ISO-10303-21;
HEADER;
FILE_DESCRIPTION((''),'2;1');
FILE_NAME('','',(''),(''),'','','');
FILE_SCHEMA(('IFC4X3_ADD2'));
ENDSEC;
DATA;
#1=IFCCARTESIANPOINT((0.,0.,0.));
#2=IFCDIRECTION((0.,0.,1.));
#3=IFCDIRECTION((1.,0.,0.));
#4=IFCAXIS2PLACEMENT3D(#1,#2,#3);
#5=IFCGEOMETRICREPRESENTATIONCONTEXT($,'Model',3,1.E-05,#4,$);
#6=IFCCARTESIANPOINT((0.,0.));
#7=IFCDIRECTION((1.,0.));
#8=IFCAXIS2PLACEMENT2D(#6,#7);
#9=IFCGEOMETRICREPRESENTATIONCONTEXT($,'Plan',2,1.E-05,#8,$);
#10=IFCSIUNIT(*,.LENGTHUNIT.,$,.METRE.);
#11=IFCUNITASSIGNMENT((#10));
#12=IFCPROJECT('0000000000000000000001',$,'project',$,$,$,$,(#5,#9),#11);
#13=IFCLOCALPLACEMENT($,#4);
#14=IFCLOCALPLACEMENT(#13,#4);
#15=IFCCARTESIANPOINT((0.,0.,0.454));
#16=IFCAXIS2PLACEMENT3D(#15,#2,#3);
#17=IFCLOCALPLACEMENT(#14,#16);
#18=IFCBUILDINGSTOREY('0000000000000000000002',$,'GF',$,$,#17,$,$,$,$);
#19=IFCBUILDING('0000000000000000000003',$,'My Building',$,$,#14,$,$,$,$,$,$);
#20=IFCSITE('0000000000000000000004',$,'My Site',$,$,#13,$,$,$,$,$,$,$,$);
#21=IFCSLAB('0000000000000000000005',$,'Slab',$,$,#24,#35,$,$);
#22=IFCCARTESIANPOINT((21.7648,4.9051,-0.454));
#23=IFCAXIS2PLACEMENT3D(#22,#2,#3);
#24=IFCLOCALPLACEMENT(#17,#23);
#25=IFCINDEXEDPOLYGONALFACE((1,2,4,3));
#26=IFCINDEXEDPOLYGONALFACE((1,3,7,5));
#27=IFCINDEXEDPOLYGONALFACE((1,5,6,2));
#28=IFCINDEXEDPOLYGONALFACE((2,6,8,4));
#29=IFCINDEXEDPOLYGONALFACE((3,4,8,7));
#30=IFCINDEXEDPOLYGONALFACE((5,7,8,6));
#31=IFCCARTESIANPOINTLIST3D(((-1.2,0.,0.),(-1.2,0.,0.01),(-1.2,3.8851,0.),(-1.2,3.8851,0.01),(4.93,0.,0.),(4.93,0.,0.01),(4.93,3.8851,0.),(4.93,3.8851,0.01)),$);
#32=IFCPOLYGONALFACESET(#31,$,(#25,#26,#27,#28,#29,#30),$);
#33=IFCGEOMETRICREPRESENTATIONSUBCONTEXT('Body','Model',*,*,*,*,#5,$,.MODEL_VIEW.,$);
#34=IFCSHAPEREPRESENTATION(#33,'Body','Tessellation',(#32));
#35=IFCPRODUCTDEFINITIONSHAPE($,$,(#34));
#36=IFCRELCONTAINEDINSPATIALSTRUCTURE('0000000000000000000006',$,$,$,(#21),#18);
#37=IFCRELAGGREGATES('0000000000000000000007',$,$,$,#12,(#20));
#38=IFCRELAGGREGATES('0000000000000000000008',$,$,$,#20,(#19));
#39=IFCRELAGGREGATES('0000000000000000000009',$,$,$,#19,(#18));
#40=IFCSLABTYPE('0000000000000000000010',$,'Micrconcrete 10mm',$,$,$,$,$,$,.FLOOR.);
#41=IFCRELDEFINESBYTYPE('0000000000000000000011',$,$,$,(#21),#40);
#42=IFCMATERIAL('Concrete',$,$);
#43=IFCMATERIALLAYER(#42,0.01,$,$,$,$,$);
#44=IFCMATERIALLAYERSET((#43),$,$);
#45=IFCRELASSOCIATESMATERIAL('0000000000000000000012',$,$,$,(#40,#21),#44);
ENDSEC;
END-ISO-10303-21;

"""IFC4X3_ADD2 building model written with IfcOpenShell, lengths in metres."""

from ifc_helpers import new_model, si_unit, frame, origin_with_axes, origin_2d_with_axis, place, context, subcontext, project, spatial, line, indexed_curve, outline, extrude, material, layer, layer_set, layer_usage, type_object, element, save


model = new_model("IFC4X3_ADD2")

# Units and contexts
model_context = context("Model", 3, precision=1e-05, world=origin_with_axes())
plan_context = context("Plan", 2, precision=1e-05, world=origin_2d_with_axis())
body_context = subcontext(model_context, "Body", "Model", "MODEL_VIEW")
ifc_project = project(units=[si_unit("LENGTHUNIT", "METRE")], contexts=[model_context, plan_context])

# Site, building, storey
site_placement = place(None, origin_with_axes())
site = spatial("IfcSite", under=ifc_project, at=site_placement, Name="My Site")
building_placement = place(site_placement, origin_with_axes())
building = spatial("IfcBuilding", under=site, at=building_placement, Name="My Building")
storey_placement = place(building_placement, frame((0.0, 0.0, 0.454), z_axis=(0.0, 0.0, 1.0), x_axis=(1.0, 0.0, 0.0)))
storey = spatial("IfcBuildingStorey", under=building, at=storey_placement, Name="GF")

# Slab
ifc_material_1 = material(Name="Concrete")
ifc_layer = layer(ifc_material_1, 0.01)
ifc_layer_set = layer_set([ifc_layer])
ifc_layer_usage = layer_usage(ifc_layer_set, "AXIS3", "POSITIVE", 0.0)
slab_type = type_object("IfcSlabType", Name="Micrconcrete 10mm", PredefinedType="FLOOR", material=ifc_layer_set)
slab_placement = place(storey_placement, frame((21.7648, 4.9051, -0.454), z_axis=(0.0, 0.0, 1.0), x_axis=(1.0, 0.0, 0.0)))
element("IfcSlab", 1, at=slab_placement, inside=storey, type_object=slab_type, material=ifc_layer_usage, Name="Slab", context=body_context, shape_type="SweptSolid", body=[
    extrude(outline(indexed_curve([(-1.2, 3.8851), (4.93, 3.8851), (4.93, 0.0), (-1.2, 0.0)], segments=[line(4, 1), line(1, 2), line(2, 3), line(3, 4)], self_intersect=False)), None, (0.0, 0.0, 1.0), 0.01),
])

save(model, "model.ifc")
